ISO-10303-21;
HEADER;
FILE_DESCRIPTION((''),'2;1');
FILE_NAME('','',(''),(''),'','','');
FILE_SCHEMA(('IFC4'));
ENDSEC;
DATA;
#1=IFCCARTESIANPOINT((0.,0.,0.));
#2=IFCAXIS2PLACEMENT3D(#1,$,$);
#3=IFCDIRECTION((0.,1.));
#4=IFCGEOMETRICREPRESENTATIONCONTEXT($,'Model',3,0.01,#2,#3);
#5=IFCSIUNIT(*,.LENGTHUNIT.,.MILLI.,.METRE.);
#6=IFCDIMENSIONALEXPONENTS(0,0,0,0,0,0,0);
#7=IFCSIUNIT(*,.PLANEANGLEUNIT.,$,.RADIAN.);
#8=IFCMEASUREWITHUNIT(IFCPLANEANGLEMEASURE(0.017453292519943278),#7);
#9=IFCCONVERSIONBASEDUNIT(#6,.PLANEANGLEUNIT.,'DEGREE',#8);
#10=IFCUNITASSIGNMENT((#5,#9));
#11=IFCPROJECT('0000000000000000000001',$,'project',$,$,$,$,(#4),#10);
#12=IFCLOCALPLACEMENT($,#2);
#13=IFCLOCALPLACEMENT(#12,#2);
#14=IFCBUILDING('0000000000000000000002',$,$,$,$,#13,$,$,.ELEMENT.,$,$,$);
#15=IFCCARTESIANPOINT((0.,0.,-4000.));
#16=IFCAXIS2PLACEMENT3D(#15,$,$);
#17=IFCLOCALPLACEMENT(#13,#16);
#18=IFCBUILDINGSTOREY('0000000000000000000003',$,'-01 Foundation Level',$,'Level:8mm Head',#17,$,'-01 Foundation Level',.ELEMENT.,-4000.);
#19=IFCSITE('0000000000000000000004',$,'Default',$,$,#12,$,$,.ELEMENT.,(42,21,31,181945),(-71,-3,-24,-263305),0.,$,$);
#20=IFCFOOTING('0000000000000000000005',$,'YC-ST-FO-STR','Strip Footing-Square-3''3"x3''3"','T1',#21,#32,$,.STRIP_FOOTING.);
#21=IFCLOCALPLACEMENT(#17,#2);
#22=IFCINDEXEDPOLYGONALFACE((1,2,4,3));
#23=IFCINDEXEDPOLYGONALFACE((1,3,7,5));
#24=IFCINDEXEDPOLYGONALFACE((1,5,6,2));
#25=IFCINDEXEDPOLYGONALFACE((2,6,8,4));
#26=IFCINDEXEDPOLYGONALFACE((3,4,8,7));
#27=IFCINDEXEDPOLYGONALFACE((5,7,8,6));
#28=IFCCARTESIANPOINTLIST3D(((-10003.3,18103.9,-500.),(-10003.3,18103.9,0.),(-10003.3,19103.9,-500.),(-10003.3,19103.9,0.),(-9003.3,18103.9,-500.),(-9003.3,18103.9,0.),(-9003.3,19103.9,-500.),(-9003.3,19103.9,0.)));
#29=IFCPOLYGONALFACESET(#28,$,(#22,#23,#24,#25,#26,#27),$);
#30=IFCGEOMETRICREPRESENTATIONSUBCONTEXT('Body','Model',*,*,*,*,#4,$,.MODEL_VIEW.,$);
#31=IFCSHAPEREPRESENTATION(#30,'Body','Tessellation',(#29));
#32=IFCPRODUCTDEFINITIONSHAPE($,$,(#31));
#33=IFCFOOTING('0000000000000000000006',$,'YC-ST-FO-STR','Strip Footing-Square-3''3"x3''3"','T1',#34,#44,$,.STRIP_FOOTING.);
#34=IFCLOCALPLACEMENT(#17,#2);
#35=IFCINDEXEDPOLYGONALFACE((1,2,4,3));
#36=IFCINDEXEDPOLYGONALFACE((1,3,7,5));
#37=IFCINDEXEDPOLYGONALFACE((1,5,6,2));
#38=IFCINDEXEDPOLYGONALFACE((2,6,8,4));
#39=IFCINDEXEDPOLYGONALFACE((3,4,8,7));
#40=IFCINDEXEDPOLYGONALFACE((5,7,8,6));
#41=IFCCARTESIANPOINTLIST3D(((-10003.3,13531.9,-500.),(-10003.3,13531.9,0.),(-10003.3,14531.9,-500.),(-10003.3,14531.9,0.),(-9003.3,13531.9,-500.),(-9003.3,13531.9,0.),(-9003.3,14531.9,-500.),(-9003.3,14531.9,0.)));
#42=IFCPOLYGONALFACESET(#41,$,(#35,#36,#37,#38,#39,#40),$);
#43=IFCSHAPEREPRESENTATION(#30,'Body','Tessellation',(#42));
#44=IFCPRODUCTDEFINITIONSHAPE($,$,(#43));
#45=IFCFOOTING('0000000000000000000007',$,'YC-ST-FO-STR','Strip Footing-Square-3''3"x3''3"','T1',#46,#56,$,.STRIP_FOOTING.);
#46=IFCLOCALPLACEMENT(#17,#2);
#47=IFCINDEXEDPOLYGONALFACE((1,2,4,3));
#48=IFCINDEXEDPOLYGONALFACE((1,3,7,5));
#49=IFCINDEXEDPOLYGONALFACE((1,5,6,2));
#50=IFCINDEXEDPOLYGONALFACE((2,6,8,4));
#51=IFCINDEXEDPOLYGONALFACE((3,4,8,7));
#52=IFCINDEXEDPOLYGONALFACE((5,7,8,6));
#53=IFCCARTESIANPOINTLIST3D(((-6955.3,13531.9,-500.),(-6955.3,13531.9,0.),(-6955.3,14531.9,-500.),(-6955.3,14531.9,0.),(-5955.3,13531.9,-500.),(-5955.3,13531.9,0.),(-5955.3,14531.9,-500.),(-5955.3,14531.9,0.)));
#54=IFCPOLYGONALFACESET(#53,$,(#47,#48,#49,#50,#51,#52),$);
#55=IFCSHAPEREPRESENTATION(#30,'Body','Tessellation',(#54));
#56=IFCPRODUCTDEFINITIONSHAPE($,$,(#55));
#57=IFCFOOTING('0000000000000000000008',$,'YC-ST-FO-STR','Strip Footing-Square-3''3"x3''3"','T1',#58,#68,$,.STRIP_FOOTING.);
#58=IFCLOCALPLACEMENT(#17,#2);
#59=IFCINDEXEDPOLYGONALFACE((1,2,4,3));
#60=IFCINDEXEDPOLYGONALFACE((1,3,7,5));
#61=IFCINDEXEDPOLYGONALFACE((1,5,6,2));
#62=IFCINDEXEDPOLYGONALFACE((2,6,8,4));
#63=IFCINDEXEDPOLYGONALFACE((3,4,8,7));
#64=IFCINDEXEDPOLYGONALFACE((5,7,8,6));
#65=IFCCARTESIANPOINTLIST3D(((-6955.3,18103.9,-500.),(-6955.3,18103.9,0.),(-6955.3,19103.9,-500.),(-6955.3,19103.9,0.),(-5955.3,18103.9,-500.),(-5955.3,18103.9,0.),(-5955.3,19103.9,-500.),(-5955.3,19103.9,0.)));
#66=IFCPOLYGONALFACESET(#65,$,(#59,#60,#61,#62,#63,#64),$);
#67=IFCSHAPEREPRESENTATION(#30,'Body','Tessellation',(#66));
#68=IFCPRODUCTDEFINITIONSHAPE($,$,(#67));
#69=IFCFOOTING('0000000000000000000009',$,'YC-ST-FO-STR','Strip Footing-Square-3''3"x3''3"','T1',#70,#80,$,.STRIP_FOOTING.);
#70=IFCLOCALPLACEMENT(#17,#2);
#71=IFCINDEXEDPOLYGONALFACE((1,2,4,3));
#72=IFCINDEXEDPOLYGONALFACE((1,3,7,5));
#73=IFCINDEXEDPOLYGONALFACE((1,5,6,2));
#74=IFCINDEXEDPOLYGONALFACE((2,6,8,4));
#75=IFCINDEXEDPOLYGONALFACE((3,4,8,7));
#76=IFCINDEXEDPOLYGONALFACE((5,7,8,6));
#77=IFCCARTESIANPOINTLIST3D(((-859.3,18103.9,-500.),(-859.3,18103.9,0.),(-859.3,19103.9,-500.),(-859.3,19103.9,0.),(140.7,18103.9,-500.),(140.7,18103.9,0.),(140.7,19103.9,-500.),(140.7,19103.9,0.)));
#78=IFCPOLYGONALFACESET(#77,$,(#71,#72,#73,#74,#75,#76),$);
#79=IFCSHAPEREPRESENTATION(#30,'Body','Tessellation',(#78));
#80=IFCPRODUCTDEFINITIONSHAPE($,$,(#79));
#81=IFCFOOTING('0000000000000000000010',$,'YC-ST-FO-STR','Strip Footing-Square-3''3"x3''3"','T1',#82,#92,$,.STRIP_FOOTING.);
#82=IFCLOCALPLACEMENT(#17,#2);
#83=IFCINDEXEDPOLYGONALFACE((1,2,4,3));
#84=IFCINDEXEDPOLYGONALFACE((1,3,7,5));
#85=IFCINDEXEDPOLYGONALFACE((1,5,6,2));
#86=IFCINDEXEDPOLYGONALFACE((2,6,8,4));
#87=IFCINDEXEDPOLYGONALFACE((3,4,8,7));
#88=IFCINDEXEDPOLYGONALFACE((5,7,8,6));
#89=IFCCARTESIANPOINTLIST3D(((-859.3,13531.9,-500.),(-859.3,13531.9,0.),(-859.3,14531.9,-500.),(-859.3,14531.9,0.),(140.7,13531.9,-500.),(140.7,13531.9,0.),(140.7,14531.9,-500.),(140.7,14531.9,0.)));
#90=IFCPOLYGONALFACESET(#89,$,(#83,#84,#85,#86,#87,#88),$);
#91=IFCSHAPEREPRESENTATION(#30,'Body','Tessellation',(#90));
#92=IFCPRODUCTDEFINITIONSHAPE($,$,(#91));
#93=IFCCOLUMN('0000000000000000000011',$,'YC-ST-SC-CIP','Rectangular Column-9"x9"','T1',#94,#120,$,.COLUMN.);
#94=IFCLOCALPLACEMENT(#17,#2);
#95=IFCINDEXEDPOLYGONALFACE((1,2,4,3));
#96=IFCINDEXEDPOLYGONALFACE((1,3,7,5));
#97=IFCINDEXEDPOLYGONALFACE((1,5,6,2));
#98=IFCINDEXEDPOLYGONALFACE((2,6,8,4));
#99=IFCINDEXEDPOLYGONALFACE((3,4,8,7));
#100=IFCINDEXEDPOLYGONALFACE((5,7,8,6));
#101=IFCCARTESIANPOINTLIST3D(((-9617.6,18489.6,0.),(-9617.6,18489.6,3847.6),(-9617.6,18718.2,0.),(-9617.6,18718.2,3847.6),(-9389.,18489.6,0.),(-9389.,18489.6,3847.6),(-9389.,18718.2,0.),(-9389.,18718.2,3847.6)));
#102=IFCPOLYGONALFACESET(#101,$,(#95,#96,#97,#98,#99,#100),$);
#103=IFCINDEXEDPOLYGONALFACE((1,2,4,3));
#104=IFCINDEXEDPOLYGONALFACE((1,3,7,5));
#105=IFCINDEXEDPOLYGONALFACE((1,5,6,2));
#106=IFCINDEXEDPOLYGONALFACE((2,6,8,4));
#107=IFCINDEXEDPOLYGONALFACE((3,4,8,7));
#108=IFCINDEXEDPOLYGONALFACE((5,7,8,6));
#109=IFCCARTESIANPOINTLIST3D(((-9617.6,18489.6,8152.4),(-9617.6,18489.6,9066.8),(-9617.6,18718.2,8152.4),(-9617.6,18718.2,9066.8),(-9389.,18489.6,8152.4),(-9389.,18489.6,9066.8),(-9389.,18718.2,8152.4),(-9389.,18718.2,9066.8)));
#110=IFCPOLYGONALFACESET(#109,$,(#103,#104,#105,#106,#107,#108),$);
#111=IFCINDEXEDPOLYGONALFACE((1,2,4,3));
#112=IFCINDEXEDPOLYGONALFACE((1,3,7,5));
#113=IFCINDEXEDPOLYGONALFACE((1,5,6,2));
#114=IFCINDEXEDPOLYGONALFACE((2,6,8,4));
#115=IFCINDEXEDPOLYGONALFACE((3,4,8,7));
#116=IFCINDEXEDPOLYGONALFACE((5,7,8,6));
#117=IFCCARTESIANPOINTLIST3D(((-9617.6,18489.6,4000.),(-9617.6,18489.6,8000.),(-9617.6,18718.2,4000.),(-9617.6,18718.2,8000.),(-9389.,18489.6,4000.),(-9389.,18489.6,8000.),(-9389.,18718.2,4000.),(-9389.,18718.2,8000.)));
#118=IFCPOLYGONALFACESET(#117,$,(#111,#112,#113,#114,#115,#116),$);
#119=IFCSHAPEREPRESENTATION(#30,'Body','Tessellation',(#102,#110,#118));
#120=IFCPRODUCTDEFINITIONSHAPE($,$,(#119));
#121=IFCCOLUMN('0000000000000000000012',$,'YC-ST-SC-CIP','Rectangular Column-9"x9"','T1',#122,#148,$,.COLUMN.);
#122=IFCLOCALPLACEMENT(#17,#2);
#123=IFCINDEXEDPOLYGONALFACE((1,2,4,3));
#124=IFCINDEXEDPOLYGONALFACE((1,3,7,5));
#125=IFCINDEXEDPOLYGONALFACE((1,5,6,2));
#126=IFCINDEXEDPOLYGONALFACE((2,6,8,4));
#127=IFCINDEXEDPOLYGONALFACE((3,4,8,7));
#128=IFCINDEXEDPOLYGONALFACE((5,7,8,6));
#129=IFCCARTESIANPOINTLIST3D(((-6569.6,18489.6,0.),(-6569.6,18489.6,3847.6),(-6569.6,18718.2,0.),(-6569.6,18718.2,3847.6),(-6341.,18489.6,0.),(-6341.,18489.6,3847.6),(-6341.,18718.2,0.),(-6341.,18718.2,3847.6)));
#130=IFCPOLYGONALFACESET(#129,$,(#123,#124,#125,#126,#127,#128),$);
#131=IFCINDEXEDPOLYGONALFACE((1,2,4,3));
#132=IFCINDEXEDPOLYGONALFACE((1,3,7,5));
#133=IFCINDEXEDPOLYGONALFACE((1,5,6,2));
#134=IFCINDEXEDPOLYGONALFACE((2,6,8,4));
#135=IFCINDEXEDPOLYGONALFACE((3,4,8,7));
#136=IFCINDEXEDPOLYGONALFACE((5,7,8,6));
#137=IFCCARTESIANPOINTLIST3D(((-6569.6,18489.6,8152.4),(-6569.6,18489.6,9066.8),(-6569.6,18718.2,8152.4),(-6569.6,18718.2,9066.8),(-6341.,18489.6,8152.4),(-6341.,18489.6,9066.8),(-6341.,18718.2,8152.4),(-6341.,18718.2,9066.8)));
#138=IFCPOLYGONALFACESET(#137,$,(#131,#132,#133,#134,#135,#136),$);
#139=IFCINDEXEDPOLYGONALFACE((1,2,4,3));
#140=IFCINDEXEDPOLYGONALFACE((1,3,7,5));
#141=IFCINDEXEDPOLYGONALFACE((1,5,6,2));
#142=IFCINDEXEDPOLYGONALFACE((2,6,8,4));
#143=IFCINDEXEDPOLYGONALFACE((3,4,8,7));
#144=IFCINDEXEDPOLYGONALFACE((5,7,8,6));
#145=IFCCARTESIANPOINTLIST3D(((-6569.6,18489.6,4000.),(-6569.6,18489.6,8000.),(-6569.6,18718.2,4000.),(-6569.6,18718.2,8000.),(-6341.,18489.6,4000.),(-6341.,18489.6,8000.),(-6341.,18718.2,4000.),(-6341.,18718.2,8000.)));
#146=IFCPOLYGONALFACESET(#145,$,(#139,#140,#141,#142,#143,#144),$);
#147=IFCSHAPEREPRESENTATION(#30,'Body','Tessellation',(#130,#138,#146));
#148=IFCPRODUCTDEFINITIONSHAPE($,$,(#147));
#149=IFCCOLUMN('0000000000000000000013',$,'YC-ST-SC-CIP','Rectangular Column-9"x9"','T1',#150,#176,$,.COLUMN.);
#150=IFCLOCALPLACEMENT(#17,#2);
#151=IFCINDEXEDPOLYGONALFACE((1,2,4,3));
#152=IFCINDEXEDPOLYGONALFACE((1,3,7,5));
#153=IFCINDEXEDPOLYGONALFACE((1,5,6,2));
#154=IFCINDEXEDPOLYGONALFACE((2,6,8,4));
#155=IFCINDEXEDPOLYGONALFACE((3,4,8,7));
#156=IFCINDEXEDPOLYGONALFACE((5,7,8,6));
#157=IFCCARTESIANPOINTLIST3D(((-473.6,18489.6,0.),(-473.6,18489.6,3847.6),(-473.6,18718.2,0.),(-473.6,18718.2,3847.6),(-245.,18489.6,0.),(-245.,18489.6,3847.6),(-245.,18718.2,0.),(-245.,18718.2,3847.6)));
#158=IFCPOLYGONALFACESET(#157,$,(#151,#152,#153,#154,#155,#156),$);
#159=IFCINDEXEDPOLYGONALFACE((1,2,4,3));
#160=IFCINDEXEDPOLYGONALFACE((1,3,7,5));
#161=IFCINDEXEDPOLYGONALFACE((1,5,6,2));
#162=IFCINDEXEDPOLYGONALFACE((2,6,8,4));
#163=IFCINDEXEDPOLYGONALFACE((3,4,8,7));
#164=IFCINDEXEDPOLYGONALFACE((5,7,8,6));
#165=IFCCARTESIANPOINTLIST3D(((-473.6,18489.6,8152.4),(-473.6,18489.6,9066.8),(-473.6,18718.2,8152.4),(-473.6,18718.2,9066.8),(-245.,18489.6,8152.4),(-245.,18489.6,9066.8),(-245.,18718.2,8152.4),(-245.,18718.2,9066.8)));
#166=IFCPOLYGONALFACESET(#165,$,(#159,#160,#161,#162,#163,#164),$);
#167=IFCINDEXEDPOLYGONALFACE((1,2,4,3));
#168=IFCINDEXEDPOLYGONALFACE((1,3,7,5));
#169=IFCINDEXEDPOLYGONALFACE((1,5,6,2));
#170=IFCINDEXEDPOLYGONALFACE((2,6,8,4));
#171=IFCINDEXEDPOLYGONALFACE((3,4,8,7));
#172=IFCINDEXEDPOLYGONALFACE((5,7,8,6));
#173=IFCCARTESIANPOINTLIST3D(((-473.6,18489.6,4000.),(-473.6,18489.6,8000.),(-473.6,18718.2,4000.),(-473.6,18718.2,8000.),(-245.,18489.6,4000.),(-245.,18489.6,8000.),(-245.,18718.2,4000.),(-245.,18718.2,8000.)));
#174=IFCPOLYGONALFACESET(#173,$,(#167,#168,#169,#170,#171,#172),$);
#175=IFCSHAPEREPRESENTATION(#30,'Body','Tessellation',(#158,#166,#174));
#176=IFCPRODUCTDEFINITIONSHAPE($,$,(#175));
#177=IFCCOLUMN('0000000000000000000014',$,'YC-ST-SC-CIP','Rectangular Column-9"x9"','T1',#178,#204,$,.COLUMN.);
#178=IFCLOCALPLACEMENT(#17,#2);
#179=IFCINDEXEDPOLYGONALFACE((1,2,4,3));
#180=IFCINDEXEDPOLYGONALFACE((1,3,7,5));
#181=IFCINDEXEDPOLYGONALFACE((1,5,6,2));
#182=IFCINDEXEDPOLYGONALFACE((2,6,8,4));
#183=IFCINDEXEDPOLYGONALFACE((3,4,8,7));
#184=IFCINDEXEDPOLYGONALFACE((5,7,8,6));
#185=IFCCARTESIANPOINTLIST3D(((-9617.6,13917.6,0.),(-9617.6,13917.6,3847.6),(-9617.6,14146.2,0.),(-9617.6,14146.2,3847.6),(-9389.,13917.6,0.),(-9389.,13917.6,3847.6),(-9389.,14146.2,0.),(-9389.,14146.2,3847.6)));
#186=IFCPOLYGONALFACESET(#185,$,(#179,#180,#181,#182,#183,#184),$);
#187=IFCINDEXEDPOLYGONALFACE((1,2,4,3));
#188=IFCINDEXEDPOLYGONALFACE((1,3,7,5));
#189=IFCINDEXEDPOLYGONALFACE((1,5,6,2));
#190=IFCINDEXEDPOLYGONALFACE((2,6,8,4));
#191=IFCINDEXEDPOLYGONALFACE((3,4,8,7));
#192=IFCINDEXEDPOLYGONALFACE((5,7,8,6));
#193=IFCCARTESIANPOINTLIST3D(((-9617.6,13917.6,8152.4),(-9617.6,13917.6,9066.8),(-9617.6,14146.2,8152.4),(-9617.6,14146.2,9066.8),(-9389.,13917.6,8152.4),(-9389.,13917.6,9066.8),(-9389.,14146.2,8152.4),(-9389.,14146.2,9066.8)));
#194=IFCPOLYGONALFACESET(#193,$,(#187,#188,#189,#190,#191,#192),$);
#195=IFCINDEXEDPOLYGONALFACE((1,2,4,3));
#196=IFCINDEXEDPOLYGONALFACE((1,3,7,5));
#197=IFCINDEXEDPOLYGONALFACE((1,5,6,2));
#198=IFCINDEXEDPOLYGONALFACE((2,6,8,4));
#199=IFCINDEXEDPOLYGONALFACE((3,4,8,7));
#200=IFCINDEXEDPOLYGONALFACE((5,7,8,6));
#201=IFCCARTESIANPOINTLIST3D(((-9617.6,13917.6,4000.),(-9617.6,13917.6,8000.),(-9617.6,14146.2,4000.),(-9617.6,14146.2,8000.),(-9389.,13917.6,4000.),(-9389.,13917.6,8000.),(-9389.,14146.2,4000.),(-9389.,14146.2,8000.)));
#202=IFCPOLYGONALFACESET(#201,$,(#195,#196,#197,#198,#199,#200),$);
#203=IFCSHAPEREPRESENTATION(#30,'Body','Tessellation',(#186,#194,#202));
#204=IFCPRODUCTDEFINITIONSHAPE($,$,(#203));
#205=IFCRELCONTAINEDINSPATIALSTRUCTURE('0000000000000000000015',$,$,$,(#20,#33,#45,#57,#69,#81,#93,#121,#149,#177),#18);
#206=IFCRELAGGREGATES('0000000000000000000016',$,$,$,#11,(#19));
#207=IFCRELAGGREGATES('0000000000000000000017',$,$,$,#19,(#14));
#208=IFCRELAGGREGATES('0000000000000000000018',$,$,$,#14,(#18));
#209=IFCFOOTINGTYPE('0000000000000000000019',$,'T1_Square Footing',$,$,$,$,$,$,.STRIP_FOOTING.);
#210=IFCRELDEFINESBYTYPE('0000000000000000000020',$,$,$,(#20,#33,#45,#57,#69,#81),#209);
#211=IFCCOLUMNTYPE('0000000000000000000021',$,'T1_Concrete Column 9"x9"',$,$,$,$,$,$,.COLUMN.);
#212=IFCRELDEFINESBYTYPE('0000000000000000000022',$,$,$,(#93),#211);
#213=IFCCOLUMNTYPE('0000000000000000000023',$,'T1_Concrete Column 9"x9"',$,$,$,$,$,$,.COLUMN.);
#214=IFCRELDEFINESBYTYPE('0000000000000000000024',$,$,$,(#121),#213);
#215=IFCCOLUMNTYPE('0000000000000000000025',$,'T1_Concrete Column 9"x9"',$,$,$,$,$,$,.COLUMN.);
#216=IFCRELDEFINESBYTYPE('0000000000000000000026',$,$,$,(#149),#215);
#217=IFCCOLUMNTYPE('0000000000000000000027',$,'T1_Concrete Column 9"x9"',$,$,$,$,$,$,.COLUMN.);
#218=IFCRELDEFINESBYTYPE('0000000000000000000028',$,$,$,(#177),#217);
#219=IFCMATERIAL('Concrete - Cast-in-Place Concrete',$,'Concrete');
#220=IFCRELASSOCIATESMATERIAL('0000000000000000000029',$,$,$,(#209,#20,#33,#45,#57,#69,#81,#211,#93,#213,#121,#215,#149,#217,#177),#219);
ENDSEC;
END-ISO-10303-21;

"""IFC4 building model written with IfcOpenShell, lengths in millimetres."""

from ifc_helpers import new_model, entity, si_unit, converted_unit, direction, frame, origin, place, context, subcontext, project, spatial, indexed_curve, outline, extrude, source, transform, mapped, material, type_object, type_shapes, element, save


model = new_model("IFC4")

# Units and contexts
model_context = context("Model", 3, precision=0.01, world=origin(), true_north=direction((0.0, 1.0)))
body_context = subcontext(model_context, "Body", "Model", "MODEL_VIEW")
ifc_project = project(units=[si_unit("LENGTHUNIT", "METRE", prefix="MILLI"), converted_unit("PLANEANGLEUNIT", "DEGREE", entity("IfcPlaneAngleMeasure", 0.017453292519943278), si_unit("PLANEANGLEUNIT", "RADIAN"), dimensions=[0, 0, 0, 0, 0, 0, 0])], contexts=[model_context])

# Site, building, storey
site_placement = place(None, origin())
site = spatial("IfcSite", under=ifc_project, at=site_placement, Name="Default", CompositionType="ELEMENT", RefLatitude=(42, 21, 31, 181945), RefLongitude=(-71, -3, -24, -263305), RefElevation=0.0)
building_placement = place(site_placement, origin())
building = spatial("IfcBuilding", under=site, at=building_placement, CompositionType="ELEMENT")
storey_placement = place(building_placement, frame((0.0, 0.0, -4000.0)))
storey = spatial("IfcBuildingStorey", under=building, at=storey_placement, Name="-01 Foundation Level", ObjectType="Level:8mm Head", LongName="-01 Foundation Level", CompositionType="ELEMENT", Elevation=-4000.0)

# Footings
ifc_material = material(Name="Concrete - Cast-in-Place Concrete", Category="Concrete")
footing_type = type_object("IfcFootingType", Name="T1_Square Footing", PredefinedType="STRIP_FOOTING", material=ifc_material)
shared_shape_1 = source(origin(), body_context, "Body", "SweptSolid", [
    extrude(outline(indexed_curve([(-500.0, -500.0), (500.0, -500.0), (500.0, 500.0), (-500.0, 500.0), (-500.0, -500.0)], self_intersect=False)), frame((0.0, 0.0, -500.0), z_axis=(0.0, 0.0, 1.0), x_axis=(-1.0, 0.0, 0.0)), (0.0, 0.0, 1.0), 500.0),
])
type_shapes(footing_type, [shared_shape_1])
for number, where, name in (
    (1, (-9503.3, 18603.9, 0.0), "YC-ST-FO-STR"),
    (2, (-9503.3, 14031.9, 0.0), "YC-ST-FO-STR"),
    (3, (-6455.3, 14031.9, 0.0), "YC-ST-FO-STR"),
    (4, (-6455.3, 18603.9, 0.0), "YC-ST-FO-STR"),
    (5, (-359.3, 18603.9, 0.0), "YC-ST-FO-STR"),
    (6, (-359.3, 14031.9, 0.0), "YC-ST-FO-STR"),
):
    element("IfcFooting", number, at=place(storey_placement, frame(where)), inside=storey, type_object=footing_type, material=ifc_material, Name=name, Description="Strip Footing-Square-3'3\"x3'3\"", ObjectType="T1", PredefinedType="STRIP_FOOTING", context=body_context, shape_type="MappedRepresentation", body=[
        mapped(shared_shape_1, transform((0.0, 0.0, 0.0), scale=1.0)),
    ])

# Columns
column_type_1 = type_object("IfcColumnType", Name="T1_Concrete Column 9\"x9\"", PredefinedType="COLUMN", material=ifc_material)
shared_shape_2 = source(origin(), body_context, "Body", "SweptSolid", [
    extrude(outline(indexed_curve([(-114.3, -114.3), (114.3, -114.3), (114.3, 114.3), (-114.3, 114.3), (-114.3, -114.3)], self_intersect=False)), frame((-9503.3, 18603.9, -4000.0), z_axis=(0.0, 0.0, 1.0), x_axis=(-1.0, 0.0, 0.0)), (0.0, 0.0, 1.0), 3847.6),
    extrude(outline(indexed_curve([(-114.3, -114.3), (114.3, -114.3), (114.3, 114.3), (-114.3, 114.3), (-114.3, -114.3)], self_intersect=False)), frame((-9503.3, 18603.9, 4152.4), z_axis=(0.0, 0.0, 1.0), x_axis=(-1.0, 0.0, 0.0)), (0.0, 0.0, 1.0), 914.4),
    extrude(outline(indexed_curve([(-114.3, -114.3), (114.3, -114.3), (114.3, 114.3), (-114.3, 114.3), (-114.3, -114.3)], self_intersect=False)), frame((-9503.3, 18603.9, 0.0), z_axis=(0.0, 0.0, 1.0), x_axis=(-1.0, 0.0, 0.0)), (0.0, 0.0, 1.0), 4000.0),
])
type_shapes(column_type_1, [shared_shape_2])
column_1_placement = place(storey_placement, frame((0.0, 0.0, 4000.0)))
element("IfcColumn", 7, at=column_1_placement, inside=storey, type_object=column_type_1, material=ifc_material, Name="YC-ST-SC-CIP", Description="Rectangular Column-9\"x9\"", ObjectType="T1", PredefinedType="COLUMN", context=body_context, shape_type="MappedRepresentation", body=[
    mapped(shared_shape_2, transform((0.0, 0.0, 0.0), scale=1.0)),
])
column_type_2 = type_object("IfcColumnType", Name="T1_Concrete Column 9\"x9\"", PredefinedType="COLUMN", material=ifc_material)
shared_shape_3 = source(origin(), body_context, "Body", "SweptSolid", [
    extrude(outline(indexed_curve([(-114.3, -114.3), (114.3, -114.3), (114.3, 114.3), (-114.3, 114.3), (-114.3, -114.3)], self_intersect=False)), frame((-6455.3, 18603.9, -4000.0), z_axis=(0.0, 0.0, 1.0), x_axis=(-1.0, 0.0, 0.0)), (0.0, 0.0, 1.0), 3847.6),
    extrude(outline(indexed_curve([(-114.3, -114.3), (114.3, -114.3), (114.3, 114.3), (-114.3, 114.3), (-114.3, -114.3)], self_intersect=False)), frame((-6455.3, 18603.9, 4152.4), z_axis=(0.0, 0.0, 1.0), x_axis=(-1.0, 0.0, 0.0)), (0.0, 0.0, 1.0), 914.4),
    extrude(outline(indexed_curve([(-114.3, -114.3), (114.3, -114.3), (114.3, 114.3), (-114.3, 114.3), (-114.3, -114.3)], self_intersect=False)), frame((-6455.3, 18603.9, 0.0), z_axis=(0.0, 0.0, 1.0), x_axis=(-1.0, 0.0, 0.0)), (0.0, 0.0, 1.0), 4000.0),
])
type_shapes(column_type_2, [shared_shape_3])
column_2_placement = place(storey_placement, frame((0.0, 0.0, 4000.0)))
element("IfcColumn", 8, at=column_2_placement, inside=storey, type_object=column_type_2, material=ifc_material, Name="YC-ST-SC-CIP", Description="Rectangular Column-9\"x9\"", ObjectType="T1", PredefinedType="COLUMN", context=body_context, shape_type="MappedRepresentation", body=[
    mapped(shared_shape_3, transform((0.0, 0.0, 0.0), scale=1.0)),
])
column_type_3 = type_object("IfcColumnType", Name="T1_Concrete Column 9\"x9\"", PredefinedType="COLUMN", material=ifc_material)
shared_shape_4 = source(origin(), body_context, "Body", "SweptSolid", [
    extrude(outline(indexed_curve([(-114.3, -114.3), (114.3, -114.3), (114.3, 114.3), (-114.3, 114.3), (-114.3, -114.3)], self_intersect=False)), frame((-359.3, 18603.9, -4000.0), z_axis=(0.0, 0.0, 1.0), x_axis=(-1.0, 0.0, 0.0)), (0.0, 0.0, 1.0), 3847.6),
    extrude(outline(indexed_curve([(-114.3, -114.3), (114.3, -114.3), (114.3, 114.3), (-114.3, 114.3), (-114.3, -114.3)], self_intersect=False)), frame((-359.3, 18603.9, 4152.4), z_axis=(0.0, 0.0, 1.0), x_axis=(-1.0, 0.0, 0.0)), (0.0, 0.0, 1.0), 914.4),
    extrude(outline(indexed_curve([(-114.3, -114.3), (114.3, -114.3), (114.3, 114.3), (-114.3, 114.3), (-114.3, -114.3)], self_intersect=False)), frame((-359.3, 18603.9, 0.0), z_axis=(0.0, 0.0, 1.0), x_axis=(-1.0, 0.0, 0.0)), (0.0, 0.0, 1.0), 4000.0),
])
type_shapes(column_type_3, [shared_shape_4])
column_3_placement = place(storey_placement, frame((0.0, 0.0, 4000.0)))
element("IfcColumn", 9, at=column_3_placement, inside=storey, type_object=column_type_3, material=ifc_material, Name="YC-ST-SC-CIP", Description="Rectangular Column-9\"x9\"", ObjectType="T1", PredefinedType="COLUMN", context=body_context, shape_type="MappedRepresentation", body=[
    mapped(shared_shape_4, transform((0.0, 0.0, 0.0), scale=1.0)),
])
column_type_4 = type_object("IfcColumnType", Name="T1_Concrete Column 9\"x9\"", PredefinedType="COLUMN", material=ifc_material)
shared_shape_5 = source(origin(), body_context, "Body", "SweptSolid", [
    extrude(outline(indexed_curve([(-114.3, -114.3), (114.3, -114.3), (114.3, 114.3), (-114.3, 114.3), (-114.3, -114.3)], self_intersect=False)), frame((-9503.3, 14031.9, -4000.0), z_axis=(0.0, 0.0, 1.0), x_axis=(-1.0, 0.0, 0.0)), (0.0, 0.0, 1.0), 3847.6),
    extrude(outline(indexed_curve([(-114.3, -114.3), (114.3, -114.3), (114.3, 114.3), (-114.3, 114.3), (-114.3, -114.3)], self_intersect=False)), frame((-9503.3, 14031.9, 4152.4), z_axis=(0.0, 0.0, 1.0), x_axis=(-1.0, 0.0, 0.0)), (0.0, 0.0, 1.0), 914.4),
    extrude(outline(indexed_curve([(-114.3, -114.3), (114.3, -114.3), (114.3, 114.3), (-114.3, 114.3), (-114.3, -114.3)], self_intersect=False)), frame((-9503.3, 14031.9, 0.0), z_axis=(0.0, 0.0, 1.0), x_axis=(-1.0, 0.0, 0.0)), (0.0, 0.0, 1.0), 4000.0),
])
type_shapes(column_type_4, [shared_shape_5])
column_4_placement = place(storey_placement, frame((0.0, 0.0, 4000.0)))
element("IfcColumn", 10, at=column_4_placement, inside=storey, type_object=column_type_4, material=ifc_material, Name="YC-ST-SC-CIP", Description="Rectangular Column-9\"x9\"", ObjectType="T1", PredefinedType="COLUMN", context=body_context, shape_type="MappedRepresentation", body=[
    mapped(shared_shape_5, transform((0.0, 0.0, 0.0), scale=1.0)),
])

save(model, "model.ifc")
